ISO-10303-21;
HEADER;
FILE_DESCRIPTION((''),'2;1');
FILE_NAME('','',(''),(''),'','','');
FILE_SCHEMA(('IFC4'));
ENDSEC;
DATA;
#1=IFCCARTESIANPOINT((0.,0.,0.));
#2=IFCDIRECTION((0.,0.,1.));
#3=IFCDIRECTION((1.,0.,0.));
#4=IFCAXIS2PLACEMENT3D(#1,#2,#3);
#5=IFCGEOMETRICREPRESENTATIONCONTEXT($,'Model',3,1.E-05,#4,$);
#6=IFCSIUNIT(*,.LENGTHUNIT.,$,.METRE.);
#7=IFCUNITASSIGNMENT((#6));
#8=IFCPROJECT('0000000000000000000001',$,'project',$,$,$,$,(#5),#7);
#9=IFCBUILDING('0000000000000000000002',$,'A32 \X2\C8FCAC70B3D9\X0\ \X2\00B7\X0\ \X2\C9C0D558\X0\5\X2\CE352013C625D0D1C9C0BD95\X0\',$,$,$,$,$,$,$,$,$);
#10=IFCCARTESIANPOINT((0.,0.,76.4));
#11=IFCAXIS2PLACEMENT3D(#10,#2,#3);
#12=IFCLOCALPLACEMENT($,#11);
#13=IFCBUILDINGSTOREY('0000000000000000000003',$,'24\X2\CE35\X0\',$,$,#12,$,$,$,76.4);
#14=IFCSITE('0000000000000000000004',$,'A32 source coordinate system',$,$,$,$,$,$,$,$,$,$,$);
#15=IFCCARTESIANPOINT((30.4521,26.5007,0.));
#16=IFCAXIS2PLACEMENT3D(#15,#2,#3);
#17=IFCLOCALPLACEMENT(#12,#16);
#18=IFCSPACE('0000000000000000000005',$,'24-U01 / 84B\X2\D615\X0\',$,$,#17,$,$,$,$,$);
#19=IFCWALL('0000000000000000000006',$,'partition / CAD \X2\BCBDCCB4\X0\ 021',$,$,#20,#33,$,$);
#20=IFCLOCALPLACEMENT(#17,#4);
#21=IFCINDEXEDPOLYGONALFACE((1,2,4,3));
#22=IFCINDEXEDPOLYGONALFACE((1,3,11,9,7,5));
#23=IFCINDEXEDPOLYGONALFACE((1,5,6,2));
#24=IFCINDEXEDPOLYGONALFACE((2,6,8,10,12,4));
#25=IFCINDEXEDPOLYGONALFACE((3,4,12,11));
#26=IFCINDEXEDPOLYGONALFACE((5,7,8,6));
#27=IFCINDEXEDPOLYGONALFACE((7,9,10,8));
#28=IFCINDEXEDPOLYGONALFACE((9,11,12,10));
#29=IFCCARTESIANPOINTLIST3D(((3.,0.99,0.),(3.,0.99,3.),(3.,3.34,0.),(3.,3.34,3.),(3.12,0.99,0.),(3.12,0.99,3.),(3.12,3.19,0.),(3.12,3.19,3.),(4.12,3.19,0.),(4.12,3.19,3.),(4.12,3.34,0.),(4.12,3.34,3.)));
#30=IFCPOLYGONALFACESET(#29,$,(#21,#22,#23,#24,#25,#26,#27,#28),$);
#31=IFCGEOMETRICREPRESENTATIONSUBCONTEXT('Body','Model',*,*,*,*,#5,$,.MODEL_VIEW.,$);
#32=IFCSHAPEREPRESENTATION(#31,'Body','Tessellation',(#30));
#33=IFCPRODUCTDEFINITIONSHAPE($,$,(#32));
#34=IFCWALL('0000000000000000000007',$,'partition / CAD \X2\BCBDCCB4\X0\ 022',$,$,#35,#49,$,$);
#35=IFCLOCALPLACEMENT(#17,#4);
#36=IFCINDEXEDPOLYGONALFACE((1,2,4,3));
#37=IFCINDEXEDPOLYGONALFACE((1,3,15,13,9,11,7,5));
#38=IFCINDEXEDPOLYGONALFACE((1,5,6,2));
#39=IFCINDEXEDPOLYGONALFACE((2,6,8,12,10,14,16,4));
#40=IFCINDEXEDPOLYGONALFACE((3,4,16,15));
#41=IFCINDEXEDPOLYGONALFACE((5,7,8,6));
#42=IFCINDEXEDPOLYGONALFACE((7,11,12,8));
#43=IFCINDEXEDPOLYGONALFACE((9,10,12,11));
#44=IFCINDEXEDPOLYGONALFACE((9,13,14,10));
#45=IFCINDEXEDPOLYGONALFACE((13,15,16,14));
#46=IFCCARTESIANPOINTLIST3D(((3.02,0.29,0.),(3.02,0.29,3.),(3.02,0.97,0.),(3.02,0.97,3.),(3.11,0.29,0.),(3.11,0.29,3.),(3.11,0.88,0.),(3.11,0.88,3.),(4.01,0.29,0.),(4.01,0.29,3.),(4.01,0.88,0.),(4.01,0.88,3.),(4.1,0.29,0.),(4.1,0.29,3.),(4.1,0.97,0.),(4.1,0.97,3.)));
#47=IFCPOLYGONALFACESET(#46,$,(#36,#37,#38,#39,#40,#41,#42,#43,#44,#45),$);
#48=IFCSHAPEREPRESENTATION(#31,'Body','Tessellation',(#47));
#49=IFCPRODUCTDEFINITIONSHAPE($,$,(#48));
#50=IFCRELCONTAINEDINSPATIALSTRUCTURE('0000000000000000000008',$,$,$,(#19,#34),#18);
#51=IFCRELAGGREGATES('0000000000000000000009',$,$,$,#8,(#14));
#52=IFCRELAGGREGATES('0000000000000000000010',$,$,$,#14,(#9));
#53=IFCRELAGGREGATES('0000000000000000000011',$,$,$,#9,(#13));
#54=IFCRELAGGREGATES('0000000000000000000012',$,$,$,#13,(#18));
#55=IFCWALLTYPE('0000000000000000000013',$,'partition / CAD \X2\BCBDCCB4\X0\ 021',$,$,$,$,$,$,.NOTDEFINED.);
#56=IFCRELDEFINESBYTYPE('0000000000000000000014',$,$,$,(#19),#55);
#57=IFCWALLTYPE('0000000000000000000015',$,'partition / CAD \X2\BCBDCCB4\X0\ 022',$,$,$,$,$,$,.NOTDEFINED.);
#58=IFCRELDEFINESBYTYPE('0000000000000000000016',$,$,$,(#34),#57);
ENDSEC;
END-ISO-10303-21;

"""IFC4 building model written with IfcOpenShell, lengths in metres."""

from ifc_helpers import new_model, si_unit, frame, origin, origin_with_axes, place, context, subcontext, project, spatial, polyline, outline, extrude, source, transform, mapped, type_object, type_shapes, element, save


model = new_model("IFC4")

# Units and contexts
model_context = context("Model", 3, precision=1e-05, world=origin_with_axes())
body_context = subcontext(model_context, "Body", "Model", "MODEL_VIEW")
ifc_project = project(units=[si_unit("LENGTHUNIT", "METRE")], contexts=[model_context])

# Site, building, storey, space
site = spatial("IfcSite", under=ifc_project, Name="A32 source coordinate system")
building = spatial("IfcBuilding", under=site, Name="A32 주거동 · 지하5층–옥탑지붕")
storey_placement = place(None, frame((0.0, 0.0, 76.4), z_axis=(0.0, 0.0, 1.0), x_axis=(1.0, 0.0, 0.0)))
storey = spatial("IfcBuildingStorey", under=building, at=storey_placement, Name="24층", Elevation=76.4)
space_placement = place(storey_placement, frame((30.4521, 26.5007, 0.0), z_axis=(0.0, 0.0, 1.0), x_axis=(1.0, 0.0, 0.0)))
space = spatial("IfcSpace", under=storey, at=space_placement, Name="24-U01 / 84B형")

# Walls
wall_type_1 = type_object("IfcWallType", Name="partition / CAD 벽체 021", PredefinedType="NOTDEFINED")
shared_shape_1 = source(origin(), body_context, "Body", "SweptSolid", [
    extrude(outline(polyline([(4.12, 3.34), (4.12, 3.19), (3.12, 3.19), (3.12, 0.99), (3.0, 0.99), (3.0, 3.34), (4.12, 3.34)])), origin(), (0.0, 0.0, 1.0), 3.0),
])
type_shapes(wall_type_1, [shared_shape_1])
wall_1_placement = place(space_placement, origin_with_axes())
element("IfcWall", 1, at=wall_1_placement, inside=space, type_object=wall_type_1, Name="partition / CAD 벽체 021", context=body_context, shape_type="MappedRepresentation", body=[
    mapped(shared_shape_1, transform((0.0, 0.0, 0.0), scale=1.0)),
])
wall_type_2 = type_object("IfcWallType", Name="partition / CAD 벽체 022", PredefinedType="NOTDEFINED")
shared_shape_2 = source(origin(), body_context, "Body", "SweptSolid", [
    extrude(outline(polyline([(4.1, 0.97), (4.1, 0.29), (4.01, 0.29), (4.01, 0.88), (3.11, 0.88), (3.11, 0.29), (3.02, 0.29), (3.02, 0.97), (4.1, 0.97)])), origin(), (0.0, 0.0, 1.0), 3.0),
])
type_shapes(wall_type_2, [shared_shape_2])
wall_2_placement = place(space_placement, origin_with_axes())
element("IfcWall", 2, at=wall_2_placement, inside=space, type_object=wall_type_2, Name="partition / CAD 벽체 022", context=body_context, shape_type="MappedRepresentation", body=[
    mapped(shared_shape_2, transform((0.0, 0.0, 0.0), scale=1.0)),
])

save(model, "model.ifc")
